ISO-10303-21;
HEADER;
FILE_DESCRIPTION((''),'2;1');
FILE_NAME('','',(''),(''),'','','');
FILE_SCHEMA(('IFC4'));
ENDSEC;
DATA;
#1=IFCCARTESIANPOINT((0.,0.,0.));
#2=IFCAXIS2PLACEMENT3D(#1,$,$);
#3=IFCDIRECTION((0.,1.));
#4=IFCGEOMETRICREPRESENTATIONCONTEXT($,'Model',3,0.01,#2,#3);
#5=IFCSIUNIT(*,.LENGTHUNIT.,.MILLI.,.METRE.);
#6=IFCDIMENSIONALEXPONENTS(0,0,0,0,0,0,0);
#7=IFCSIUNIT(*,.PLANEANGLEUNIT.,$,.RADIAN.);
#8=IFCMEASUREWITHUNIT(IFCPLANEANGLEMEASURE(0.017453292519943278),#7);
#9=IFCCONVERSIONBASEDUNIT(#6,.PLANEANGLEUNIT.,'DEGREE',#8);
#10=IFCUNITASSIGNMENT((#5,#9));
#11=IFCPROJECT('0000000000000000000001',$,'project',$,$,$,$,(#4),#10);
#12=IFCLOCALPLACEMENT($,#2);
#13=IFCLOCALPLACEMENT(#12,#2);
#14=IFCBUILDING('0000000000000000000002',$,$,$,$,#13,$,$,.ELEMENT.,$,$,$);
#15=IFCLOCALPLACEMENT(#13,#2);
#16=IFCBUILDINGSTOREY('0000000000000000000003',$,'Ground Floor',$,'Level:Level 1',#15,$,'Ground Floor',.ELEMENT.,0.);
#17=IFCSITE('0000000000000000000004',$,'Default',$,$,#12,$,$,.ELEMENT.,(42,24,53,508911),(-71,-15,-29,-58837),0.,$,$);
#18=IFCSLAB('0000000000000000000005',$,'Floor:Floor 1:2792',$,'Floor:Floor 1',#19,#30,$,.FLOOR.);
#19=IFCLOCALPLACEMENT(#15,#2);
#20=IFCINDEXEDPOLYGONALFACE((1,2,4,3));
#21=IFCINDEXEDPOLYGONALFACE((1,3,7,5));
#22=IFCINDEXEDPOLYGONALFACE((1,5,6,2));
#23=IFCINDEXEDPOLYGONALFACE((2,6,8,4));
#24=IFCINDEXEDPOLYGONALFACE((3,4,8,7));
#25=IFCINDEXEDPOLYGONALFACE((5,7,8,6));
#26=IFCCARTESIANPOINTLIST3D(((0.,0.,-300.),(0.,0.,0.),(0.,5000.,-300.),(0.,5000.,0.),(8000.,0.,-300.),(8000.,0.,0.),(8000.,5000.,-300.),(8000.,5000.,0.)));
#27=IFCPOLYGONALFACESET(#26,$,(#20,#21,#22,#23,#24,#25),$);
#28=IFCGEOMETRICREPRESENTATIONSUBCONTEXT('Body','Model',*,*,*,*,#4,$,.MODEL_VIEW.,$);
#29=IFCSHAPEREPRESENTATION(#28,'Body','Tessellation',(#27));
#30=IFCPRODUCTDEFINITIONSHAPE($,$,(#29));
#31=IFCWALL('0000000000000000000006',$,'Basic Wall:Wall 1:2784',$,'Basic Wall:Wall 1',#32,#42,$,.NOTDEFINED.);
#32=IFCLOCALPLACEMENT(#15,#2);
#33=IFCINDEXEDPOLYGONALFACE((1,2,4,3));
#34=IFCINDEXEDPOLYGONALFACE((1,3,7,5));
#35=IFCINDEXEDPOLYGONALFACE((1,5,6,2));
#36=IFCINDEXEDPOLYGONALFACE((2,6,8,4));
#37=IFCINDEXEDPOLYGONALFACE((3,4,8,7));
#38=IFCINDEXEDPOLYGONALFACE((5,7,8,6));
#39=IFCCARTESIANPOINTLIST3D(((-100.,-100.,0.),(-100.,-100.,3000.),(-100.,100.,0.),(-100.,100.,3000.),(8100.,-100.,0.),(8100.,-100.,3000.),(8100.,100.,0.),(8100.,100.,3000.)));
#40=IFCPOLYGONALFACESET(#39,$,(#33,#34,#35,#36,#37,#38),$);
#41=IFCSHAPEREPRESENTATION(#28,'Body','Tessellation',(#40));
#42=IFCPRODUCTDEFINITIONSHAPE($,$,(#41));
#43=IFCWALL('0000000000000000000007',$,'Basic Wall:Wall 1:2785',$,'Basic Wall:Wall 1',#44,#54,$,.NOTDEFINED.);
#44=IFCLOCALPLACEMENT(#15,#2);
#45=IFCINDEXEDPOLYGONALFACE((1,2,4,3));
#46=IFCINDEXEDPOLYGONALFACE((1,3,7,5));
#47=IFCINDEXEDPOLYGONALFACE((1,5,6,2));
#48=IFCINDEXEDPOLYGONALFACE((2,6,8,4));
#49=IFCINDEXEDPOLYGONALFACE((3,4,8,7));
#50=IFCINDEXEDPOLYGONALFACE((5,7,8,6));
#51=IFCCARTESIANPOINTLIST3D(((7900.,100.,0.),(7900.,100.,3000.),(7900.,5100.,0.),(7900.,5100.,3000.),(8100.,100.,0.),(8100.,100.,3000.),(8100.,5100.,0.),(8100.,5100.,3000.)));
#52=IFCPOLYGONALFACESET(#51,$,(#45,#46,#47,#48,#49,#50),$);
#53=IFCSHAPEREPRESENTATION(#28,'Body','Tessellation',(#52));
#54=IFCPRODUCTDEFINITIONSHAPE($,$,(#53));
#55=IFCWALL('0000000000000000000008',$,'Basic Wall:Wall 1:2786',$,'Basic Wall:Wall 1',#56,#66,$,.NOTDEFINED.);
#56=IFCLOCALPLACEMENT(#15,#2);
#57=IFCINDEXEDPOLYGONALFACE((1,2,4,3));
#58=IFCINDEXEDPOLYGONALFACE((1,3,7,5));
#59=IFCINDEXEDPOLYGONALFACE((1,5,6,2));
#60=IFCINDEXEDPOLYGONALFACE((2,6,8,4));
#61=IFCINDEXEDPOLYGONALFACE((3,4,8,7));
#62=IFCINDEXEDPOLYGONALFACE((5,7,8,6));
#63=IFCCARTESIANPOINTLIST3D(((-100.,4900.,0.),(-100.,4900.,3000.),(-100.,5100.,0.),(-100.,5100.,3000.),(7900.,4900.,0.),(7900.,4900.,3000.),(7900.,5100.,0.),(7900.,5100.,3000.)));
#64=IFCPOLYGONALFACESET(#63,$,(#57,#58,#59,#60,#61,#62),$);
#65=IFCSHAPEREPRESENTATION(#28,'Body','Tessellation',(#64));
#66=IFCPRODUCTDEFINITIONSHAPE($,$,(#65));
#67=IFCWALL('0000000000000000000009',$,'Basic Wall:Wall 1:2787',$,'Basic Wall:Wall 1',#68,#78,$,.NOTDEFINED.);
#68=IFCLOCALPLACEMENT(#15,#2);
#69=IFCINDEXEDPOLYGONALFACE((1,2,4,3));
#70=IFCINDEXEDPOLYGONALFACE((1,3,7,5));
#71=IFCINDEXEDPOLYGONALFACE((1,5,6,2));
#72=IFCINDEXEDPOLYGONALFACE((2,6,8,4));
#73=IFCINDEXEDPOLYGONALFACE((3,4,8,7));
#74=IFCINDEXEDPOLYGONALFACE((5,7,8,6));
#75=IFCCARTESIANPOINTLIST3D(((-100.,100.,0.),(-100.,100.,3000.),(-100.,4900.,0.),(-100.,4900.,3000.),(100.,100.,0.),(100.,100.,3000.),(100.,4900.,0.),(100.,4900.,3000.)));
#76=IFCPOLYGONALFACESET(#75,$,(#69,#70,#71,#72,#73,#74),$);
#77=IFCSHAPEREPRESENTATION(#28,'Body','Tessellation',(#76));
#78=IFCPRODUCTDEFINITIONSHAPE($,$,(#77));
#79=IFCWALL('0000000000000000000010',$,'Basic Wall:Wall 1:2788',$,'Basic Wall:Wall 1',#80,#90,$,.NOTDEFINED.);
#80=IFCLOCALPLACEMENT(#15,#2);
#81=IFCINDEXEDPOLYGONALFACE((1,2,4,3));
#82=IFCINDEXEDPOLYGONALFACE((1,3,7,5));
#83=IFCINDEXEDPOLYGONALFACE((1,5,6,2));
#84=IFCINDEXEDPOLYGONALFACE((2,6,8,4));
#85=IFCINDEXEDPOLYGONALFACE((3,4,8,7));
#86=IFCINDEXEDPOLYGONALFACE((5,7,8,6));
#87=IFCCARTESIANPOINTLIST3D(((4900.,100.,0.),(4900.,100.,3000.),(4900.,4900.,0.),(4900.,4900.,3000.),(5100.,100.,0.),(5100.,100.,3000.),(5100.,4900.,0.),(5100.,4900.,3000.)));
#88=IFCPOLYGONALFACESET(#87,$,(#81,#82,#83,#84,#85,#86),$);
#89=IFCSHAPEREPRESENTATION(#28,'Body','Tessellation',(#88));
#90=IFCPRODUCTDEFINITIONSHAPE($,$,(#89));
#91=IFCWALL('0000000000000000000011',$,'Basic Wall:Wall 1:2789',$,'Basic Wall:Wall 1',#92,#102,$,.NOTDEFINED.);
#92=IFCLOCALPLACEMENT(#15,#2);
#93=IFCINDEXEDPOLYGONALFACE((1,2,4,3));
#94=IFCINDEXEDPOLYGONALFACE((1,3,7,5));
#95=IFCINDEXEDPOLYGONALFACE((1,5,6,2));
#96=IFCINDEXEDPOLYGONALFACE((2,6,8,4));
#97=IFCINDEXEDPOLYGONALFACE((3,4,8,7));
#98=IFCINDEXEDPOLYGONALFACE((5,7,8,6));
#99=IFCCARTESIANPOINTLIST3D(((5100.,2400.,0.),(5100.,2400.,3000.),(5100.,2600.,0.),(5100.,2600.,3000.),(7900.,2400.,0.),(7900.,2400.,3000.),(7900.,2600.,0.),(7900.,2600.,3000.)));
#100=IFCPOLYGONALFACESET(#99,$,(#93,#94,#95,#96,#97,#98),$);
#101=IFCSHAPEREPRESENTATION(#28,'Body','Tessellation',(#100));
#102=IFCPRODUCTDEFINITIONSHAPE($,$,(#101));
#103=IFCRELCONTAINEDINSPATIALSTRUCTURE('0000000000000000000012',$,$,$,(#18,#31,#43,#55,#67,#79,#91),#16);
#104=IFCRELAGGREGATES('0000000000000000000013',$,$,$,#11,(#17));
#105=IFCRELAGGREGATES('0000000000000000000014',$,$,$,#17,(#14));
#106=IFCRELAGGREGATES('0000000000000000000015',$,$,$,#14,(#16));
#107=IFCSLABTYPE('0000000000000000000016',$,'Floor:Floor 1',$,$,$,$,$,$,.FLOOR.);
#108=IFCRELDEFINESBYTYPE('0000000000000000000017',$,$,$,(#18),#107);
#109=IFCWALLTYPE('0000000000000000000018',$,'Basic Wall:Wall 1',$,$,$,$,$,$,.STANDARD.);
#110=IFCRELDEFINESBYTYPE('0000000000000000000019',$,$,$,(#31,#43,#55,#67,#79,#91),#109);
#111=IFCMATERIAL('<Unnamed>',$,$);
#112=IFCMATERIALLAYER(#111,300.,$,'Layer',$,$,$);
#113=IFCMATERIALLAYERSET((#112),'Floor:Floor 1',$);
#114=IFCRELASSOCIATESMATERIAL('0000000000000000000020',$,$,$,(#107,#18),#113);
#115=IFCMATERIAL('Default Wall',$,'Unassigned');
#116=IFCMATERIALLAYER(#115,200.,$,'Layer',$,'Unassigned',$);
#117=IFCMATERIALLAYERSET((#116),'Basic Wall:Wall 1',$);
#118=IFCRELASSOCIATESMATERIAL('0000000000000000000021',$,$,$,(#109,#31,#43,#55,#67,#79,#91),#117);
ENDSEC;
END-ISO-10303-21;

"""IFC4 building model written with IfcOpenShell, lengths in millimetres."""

from ifc_helpers import new_model, entity, si_unit, converted_unit, direction, frame, frame_2d, origin, origin_2d_with_axis, place, context, subcontext, project, spatial, rectangle, extrude, material, layer, layer_set, layer_usage, type_object, element, save


model = new_model("IFC4")

# Units and contexts
model_context = context("Model", 3, precision=0.01, world=origin(), true_north=direction((0.0, 1.0)))
body_context = subcontext(model_context, "Body", "Model", "MODEL_VIEW")
ifc_project = project(units=[si_unit("LENGTHUNIT", "METRE", prefix="MILLI"), converted_unit("PLANEANGLEUNIT", "DEGREE", entity("IfcPlaneAngleMeasure", 0.017453292519943278), si_unit("PLANEANGLEUNIT", "RADIAN"), dimensions=[0, 0, 0, 0, 0, 0, 0])], contexts=[model_context])

# Site, building, storey
site_placement = place(None, origin())
site = spatial("IfcSite", under=ifc_project, at=site_placement, Name="Default", CompositionType="ELEMENT", RefLatitude=(42, 24, 53, 508911), RefLongitude=(-71, -15, -29, -58837), RefElevation=0.0)
building_placement = place(site_placement, origin())
building = spatial("IfcBuilding", under=site, at=building_placement, CompositionType="ELEMENT")
storey_placement = place(building_placement, origin())
storey = spatial("IfcBuildingStorey", under=building, at=storey_placement, Name="Ground Floor", ObjectType="Level:Level 1", LongName="Ground Floor", CompositionType="ELEMENT", Elevation=0.0)

# Slab
ifc_material_1 = material(Name="<Unnamed>")
ifc_layer_1 = layer(ifc_material_1, 300.0, Name="Layer")
ifc_layer_set_1 = layer_set([ifc_layer_1], Name="Floor:Floor 1")
ifc_layer_usage_1 = layer_usage(ifc_layer_set_1, "AXIS3", "POSITIVE", 0.0)
slab_type = type_object("IfcSlabType", Name="Floor:Floor 1", PredefinedType="FLOOR", material=ifc_layer_set_1)
slab_placement = place(storey_placement, origin())
element("IfcSlab", 1, at=slab_placement, inside=storey, type_object=slab_type, material=ifc_layer_usage_1, Name="Floor:Floor 1:2792", ObjectType="Floor:Floor 1", PredefinedType="FLOOR", context=body_context, shape_type="SweptSolid", body=[
    extrude(rectangle(XDim=5000.0, YDim=8000.0, at=origin_2d_with_axis()), frame((4000.0, 2500.0, 0.0), z_axis=(0.0, 0.0, -1.0), x_axis=(0.0, 1.0, 0.0)), (0.0, 0.0, 1.0), 300.0),
])

# Walls
ifc_material_2 = material(Name="Default Wall", Category="Unassigned")
ifc_layer_2 = layer(ifc_material_2, 200.0, Name="Layer", Category="Unassigned")
ifc_layer_set_2 = layer_set([ifc_layer_2], Name="Basic Wall:Wall 1")
ifc_layer_usage_2 = layer_usage(ifc_layer_set_2, "AXIS2", "NEGATIVE", 100.0)
wall_type = type_object("IfcWallType", Name="Basic Wall:Wall 1", PredefinedType="STANDARD", material=ifc_layer_set_2)
wall_1_placement = place(storey_placement, frame((-100.0, 0.0, 0.0)))
element("IfcWall", 2, at=wall_1_placement, inside=storey, type_object=wall_type, material=ifc_layer_usage_2, Name="Basic Wall:Wall 1:2784", ObjectType="Basic Wall:Wall 1", PredefinedType="NOTDEFINED", context=body_context, shape_type="SweptSolid", body=[
    extrude(rectangle(XDim=8200.0, YDim=200.0, at=frame_2d((4100.0, 0.0), x_axis=(-1.0, 0.0))), origin(), (0.0, 0.0, 1.0), 3000.0),
])
ifc_layer_usage_3 = layer_usage(ifc_layer_set_2, "AXIS2", "NEGATIVE", 100.0)
wall_2_placement = place(storey_placement, frame((8000.0, 100.0, 0.0), z_axis=(0.0, 0.0, 1.0), x_axis=(0.0, 1.0, 0.0)))
element("IfcWall", 3, at=wall_2_placement, inside=storey, type_object=wall_type, material=ifc_layer_usage_3, Name="Basic Wall:Wall 1:2785", ObjectType="Basic Wall:Wall 1", PredefinedType="NOTDEFINED", context=body_context, shape_type="SweptSolid", body=[
    extrude(rectangle(XDim=5000.0, YDim=200.0, at=frame_2d((2500.0, 0.0), x_axis=(-1.0, 0.0))), origin(), (0.0, 0.0, 1.0), 3000.0),
])
ifc_layer_usage_4 = layer_usage(ifc_layer_set_2, "AXIS2", "NEGATIVE", 100.0)
wall_3_placement = place(storey_placement, frame((7900.0, 5000.0, 0.0), z_axis=(0.0, 0.0, 1.0), x_axis=(-1.0, 0.0, 0.0)))
element("IfcWall", 4, at=wall_3_placement, inside=storey, type_object=wall_type, material=ifc_layer_usage_4, Name="Basic Wall:Wall 1:2786", ObjectType="Basic Wall:Wall 1", PredefinedType="NOTDEFINED", context=body_context, shape_type="SweptSolid", body=[
    extrude(rectangle(XDim=8000.0, YDim=200.0, at=frame_2d((4000.0, 0.0), x_axis=(-1.0, 0.0))), origin(), (0.0, 0.0, 1.0), 3000.0),
])
ifc_layer_usage_5 = layer_usage(ifc_layer_set_2, "AXIS2", "NEGATIVE", 100.0)
wall_4_placement = place(storey_placement, frame((0.0, 4900.0, 0.0), z_axis=(0.0, 0.0, 1.0), x_axis=(0.0, -1.0, 0.0)))
element("IfcWall", 5, at=wall_4_placement, inside=storey, type_object=wall_type, material=ifc_layer_usage_5, Name="Basic Wall:Wall 1:2787", ObjectType="Basic Wall:Wall 1", PredefinedType="NOTDEFINED", context=body_context, shape_type="SweptSolid", body=[
    extrude(rectangle(XDim=4800.0, YDim=200.0, at=frame_2d((2400.0, 0.0), x_axis=(-1.0, 0.0))), origin(), (0.0, 0.0, 1.0), 3000.0),
])
ifc_layer_usage_6 = layer_usage(ifc_layer_set_2, "AXIS2", "NEGATIVE", 100.0)
wall_5_placement = place(storey_placement, frame((5000.0, 100.0, 0.0), z_axis=(0.0, 0.0, 1.0), x_axis=(0.0, 1.0, 0.0)))
element("IfcWall", 6, at=wall_5_placement, inside=storey, type_object=wall_type, material=ifc_layer_usage_6, Name="Basic Wall:Wall 1:2788", ObjectType="Basic Wall:Wall 1", PredefinedType="NOTDEFINED", context=body_context, shape_type="SweptSolid", body=[
    extrude(rectangle(XDim=4800.0, YDim=200.0, at=frame_2d((2400.0, 0.0), x_axis=(-1.0, 0.0))), origin(), (0.0, 0.0, 1.0), 3000.0),
])
ifc_layer_usage_7 = layer_usage(ifc_layer_set_2, "AXIS2", "NEGATIVE", 100.0)
wall_6_placement = place(storey_placement, frame((5100.0, 2500.0, 0.0)))
element("IfcWall", 7, at=wall_6_placement, inside=storey, type_object=wall_type, material=ifc_layer_usage_7, Name="Basic Wall:Wall 1:2789", ObjectType="Basic Wall:Wall 1", PredefinedType="NOTDEFINED", context=body_context, shape_type="SweptSolid", body=[
    extrude(rectangle(XDim=2800.0, YDim=200.0, at=frame_2d((1400.0, 0.0), x_axis=(-1.0, 0.0))), origin(), (0.0, 0.0, 1.0), 3000.0),
])

save(model, "model.ifc")
